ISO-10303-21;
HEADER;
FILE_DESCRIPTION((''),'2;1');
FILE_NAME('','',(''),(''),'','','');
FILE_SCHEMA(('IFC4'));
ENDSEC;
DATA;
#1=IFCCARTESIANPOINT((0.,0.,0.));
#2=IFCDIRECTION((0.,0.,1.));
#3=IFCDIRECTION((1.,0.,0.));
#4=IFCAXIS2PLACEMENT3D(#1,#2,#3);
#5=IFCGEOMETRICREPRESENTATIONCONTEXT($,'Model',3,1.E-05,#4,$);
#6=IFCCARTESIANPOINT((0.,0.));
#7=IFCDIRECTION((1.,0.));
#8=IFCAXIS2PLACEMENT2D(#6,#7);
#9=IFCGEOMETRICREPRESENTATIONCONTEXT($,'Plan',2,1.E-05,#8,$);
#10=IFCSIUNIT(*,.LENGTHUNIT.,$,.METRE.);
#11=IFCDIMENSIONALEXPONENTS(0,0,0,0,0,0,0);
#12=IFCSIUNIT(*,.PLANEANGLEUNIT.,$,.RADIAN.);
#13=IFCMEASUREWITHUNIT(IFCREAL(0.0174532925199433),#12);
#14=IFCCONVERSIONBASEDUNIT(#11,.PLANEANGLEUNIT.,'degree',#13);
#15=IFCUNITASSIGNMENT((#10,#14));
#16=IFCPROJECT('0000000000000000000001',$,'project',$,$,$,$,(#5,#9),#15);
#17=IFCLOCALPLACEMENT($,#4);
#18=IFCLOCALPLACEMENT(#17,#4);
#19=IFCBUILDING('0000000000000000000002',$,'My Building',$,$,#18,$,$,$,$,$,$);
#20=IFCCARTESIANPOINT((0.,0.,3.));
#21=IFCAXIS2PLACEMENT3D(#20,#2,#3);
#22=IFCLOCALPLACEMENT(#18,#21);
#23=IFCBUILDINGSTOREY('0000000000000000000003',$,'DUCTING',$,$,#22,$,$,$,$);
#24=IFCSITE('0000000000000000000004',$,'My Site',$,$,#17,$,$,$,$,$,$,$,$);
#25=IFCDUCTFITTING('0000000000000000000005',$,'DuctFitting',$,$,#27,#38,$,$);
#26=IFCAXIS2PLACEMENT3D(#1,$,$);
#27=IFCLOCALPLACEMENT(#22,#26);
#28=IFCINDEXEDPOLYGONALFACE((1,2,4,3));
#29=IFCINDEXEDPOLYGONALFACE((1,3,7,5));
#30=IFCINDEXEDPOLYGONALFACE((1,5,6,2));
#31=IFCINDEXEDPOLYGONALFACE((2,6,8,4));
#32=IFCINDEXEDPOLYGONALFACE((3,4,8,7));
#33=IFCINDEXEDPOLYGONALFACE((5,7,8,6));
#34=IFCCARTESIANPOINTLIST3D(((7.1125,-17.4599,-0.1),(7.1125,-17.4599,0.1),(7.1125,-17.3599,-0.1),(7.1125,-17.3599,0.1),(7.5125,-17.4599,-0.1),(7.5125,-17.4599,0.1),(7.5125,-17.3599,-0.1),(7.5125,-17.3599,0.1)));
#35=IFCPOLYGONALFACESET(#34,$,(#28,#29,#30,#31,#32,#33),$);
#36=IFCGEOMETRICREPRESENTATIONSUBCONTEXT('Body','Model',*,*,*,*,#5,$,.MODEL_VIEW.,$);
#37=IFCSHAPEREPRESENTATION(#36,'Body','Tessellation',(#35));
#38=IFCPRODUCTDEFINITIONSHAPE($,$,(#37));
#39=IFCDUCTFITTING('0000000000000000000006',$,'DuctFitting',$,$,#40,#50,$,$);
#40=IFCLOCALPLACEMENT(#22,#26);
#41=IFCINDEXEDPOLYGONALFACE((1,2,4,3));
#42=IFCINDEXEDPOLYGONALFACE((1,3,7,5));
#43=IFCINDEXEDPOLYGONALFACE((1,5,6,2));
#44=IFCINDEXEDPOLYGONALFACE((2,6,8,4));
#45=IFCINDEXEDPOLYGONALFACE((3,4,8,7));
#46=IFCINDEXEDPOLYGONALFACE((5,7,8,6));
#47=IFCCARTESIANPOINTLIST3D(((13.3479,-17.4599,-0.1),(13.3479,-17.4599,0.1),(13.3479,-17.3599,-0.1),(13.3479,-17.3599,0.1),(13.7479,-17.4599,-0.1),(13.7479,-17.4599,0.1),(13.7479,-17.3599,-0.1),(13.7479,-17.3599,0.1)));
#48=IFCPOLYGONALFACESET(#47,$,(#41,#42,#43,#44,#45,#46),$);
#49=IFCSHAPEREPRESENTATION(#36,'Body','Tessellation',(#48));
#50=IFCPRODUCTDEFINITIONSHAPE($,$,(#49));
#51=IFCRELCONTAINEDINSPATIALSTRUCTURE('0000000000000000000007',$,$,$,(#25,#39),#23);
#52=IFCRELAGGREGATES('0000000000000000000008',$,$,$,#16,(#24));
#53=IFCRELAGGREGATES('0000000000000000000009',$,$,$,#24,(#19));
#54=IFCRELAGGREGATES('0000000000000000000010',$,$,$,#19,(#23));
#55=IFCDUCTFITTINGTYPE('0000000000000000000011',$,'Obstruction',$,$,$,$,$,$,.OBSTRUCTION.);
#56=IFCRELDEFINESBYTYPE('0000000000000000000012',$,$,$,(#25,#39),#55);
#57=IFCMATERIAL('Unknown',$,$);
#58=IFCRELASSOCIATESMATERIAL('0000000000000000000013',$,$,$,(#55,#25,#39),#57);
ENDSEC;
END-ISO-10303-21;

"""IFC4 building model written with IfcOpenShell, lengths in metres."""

from ifc_helpers import new_model, entity, si_unit, converted_unit, frame, origin_with_axes, origin_2d_with_axis, place, context, subcontext, project, spatial, rectangle, extrude, material, material_profile, profile_set, profile_usage, type_object, element, save


model = new_model("IFC4")

# Units and contexts
model_context = context("Model", 3, precision=1e-05, world=origin_with_axes())
plan_context = context("Plan", 2, precision=1e-05, world=origin_2d_with_axis())
body_context = subcontext(model_context, "Body", "Model", "MODEL_VIEW")
ifc_project = project(units=[si_unit("LENGTHUNIT", "METRE"), converted_unit("PLANEANGLEUNIT", "degree", entity("IfcReal", 0.0174532925199433), si_unit("PLANEANGLEUNIT", "RADIAN"), dimensions=[0, 0, 0, 0, 0, 0, 0])], contexts=[model_context, plan_context])

# Site, building, storey
site_placement = place(None, origin_with_axes())
site = spatial("IfcSite", under=ifc_project, at=site_placement, Name="My Site")
building_placement = place(site_placement, origin_with_axes())
building = spatial("IfcBuilding", under=site, at=building_placement, Name="My Building")
storey_placement = place(building_placement, frame((0.0, 0.0, 3.0), z_axis=(0.0, 0.0, 1.0), x_axis=(1.0, 0.0, 0.0)))
storey = spatial("IfcBuildingStorey", under=building, at=storey_placement, Name="DUCTING")

# Shared definitions
ifc_material = material(Name="Unknown")

# Duct fittings
ifc_material_profile_1 = material_profile(ifc_material, rectangle(XDim=0.4, YDim=0.2))
ifc_profile_set_1 = profile_set([ifc_material_profile_1])
duct_fitting_type_1 = type_object("IfcDuctFittingType", Name="Obstruction", PredefinedType="OBSTRUCTION", material=ifc_profile_set_1)
ifc_profile_usage_1 = profile_usage(ifc_profile_set_1, cardinal=5)
duct_fitting_1_placement = place(storey_placement, frame((7.3125, -17.4599, 0.0), z_axis=(0.000001, 1.0, 0.0), x_axis=(-1.0, 0.000001, 0.0)))
element("IfcDuctFitting", 1, at=duct_fitting_1_placement, inside=storey, type_object=duct_fitting_type_1, material=ifc_profile_usage_1, Name="DuctFitting", context=body_context, shape_type="SweptSolid", body=[
    extrude(rectangle(XDim=0.4, YDim=0.2), origin_with_axes(), (0.0, 0.0, 1.0), 0.1),
])
ifc_profile_usage_2 = profile_usage(ifc_profile_set_1, cardinal=5)
duct_fitting_2_placement = place(storey_placement, frame((13.5479, -17.4599, 0.0), z_axis=(0.000001, 1.0, 0.0), x_axis=(-1.0, 0.000001, 0.0)))
element("IfcDuctFitting", 2, at=duct_fitting_2_placement, inside=storey, type_object=duct_fitting_type_1, material=ifc_profile_usage_2, Name="DuctFitting", context=body_context, shape_type="SweptSolid", body=[
    extrude(rectangle(XDim=0.4, YDim=0.2), origin_with_axes(), (0.0, 0.0, 1.0), 0.1),
])

save(model, "model.ifc")
